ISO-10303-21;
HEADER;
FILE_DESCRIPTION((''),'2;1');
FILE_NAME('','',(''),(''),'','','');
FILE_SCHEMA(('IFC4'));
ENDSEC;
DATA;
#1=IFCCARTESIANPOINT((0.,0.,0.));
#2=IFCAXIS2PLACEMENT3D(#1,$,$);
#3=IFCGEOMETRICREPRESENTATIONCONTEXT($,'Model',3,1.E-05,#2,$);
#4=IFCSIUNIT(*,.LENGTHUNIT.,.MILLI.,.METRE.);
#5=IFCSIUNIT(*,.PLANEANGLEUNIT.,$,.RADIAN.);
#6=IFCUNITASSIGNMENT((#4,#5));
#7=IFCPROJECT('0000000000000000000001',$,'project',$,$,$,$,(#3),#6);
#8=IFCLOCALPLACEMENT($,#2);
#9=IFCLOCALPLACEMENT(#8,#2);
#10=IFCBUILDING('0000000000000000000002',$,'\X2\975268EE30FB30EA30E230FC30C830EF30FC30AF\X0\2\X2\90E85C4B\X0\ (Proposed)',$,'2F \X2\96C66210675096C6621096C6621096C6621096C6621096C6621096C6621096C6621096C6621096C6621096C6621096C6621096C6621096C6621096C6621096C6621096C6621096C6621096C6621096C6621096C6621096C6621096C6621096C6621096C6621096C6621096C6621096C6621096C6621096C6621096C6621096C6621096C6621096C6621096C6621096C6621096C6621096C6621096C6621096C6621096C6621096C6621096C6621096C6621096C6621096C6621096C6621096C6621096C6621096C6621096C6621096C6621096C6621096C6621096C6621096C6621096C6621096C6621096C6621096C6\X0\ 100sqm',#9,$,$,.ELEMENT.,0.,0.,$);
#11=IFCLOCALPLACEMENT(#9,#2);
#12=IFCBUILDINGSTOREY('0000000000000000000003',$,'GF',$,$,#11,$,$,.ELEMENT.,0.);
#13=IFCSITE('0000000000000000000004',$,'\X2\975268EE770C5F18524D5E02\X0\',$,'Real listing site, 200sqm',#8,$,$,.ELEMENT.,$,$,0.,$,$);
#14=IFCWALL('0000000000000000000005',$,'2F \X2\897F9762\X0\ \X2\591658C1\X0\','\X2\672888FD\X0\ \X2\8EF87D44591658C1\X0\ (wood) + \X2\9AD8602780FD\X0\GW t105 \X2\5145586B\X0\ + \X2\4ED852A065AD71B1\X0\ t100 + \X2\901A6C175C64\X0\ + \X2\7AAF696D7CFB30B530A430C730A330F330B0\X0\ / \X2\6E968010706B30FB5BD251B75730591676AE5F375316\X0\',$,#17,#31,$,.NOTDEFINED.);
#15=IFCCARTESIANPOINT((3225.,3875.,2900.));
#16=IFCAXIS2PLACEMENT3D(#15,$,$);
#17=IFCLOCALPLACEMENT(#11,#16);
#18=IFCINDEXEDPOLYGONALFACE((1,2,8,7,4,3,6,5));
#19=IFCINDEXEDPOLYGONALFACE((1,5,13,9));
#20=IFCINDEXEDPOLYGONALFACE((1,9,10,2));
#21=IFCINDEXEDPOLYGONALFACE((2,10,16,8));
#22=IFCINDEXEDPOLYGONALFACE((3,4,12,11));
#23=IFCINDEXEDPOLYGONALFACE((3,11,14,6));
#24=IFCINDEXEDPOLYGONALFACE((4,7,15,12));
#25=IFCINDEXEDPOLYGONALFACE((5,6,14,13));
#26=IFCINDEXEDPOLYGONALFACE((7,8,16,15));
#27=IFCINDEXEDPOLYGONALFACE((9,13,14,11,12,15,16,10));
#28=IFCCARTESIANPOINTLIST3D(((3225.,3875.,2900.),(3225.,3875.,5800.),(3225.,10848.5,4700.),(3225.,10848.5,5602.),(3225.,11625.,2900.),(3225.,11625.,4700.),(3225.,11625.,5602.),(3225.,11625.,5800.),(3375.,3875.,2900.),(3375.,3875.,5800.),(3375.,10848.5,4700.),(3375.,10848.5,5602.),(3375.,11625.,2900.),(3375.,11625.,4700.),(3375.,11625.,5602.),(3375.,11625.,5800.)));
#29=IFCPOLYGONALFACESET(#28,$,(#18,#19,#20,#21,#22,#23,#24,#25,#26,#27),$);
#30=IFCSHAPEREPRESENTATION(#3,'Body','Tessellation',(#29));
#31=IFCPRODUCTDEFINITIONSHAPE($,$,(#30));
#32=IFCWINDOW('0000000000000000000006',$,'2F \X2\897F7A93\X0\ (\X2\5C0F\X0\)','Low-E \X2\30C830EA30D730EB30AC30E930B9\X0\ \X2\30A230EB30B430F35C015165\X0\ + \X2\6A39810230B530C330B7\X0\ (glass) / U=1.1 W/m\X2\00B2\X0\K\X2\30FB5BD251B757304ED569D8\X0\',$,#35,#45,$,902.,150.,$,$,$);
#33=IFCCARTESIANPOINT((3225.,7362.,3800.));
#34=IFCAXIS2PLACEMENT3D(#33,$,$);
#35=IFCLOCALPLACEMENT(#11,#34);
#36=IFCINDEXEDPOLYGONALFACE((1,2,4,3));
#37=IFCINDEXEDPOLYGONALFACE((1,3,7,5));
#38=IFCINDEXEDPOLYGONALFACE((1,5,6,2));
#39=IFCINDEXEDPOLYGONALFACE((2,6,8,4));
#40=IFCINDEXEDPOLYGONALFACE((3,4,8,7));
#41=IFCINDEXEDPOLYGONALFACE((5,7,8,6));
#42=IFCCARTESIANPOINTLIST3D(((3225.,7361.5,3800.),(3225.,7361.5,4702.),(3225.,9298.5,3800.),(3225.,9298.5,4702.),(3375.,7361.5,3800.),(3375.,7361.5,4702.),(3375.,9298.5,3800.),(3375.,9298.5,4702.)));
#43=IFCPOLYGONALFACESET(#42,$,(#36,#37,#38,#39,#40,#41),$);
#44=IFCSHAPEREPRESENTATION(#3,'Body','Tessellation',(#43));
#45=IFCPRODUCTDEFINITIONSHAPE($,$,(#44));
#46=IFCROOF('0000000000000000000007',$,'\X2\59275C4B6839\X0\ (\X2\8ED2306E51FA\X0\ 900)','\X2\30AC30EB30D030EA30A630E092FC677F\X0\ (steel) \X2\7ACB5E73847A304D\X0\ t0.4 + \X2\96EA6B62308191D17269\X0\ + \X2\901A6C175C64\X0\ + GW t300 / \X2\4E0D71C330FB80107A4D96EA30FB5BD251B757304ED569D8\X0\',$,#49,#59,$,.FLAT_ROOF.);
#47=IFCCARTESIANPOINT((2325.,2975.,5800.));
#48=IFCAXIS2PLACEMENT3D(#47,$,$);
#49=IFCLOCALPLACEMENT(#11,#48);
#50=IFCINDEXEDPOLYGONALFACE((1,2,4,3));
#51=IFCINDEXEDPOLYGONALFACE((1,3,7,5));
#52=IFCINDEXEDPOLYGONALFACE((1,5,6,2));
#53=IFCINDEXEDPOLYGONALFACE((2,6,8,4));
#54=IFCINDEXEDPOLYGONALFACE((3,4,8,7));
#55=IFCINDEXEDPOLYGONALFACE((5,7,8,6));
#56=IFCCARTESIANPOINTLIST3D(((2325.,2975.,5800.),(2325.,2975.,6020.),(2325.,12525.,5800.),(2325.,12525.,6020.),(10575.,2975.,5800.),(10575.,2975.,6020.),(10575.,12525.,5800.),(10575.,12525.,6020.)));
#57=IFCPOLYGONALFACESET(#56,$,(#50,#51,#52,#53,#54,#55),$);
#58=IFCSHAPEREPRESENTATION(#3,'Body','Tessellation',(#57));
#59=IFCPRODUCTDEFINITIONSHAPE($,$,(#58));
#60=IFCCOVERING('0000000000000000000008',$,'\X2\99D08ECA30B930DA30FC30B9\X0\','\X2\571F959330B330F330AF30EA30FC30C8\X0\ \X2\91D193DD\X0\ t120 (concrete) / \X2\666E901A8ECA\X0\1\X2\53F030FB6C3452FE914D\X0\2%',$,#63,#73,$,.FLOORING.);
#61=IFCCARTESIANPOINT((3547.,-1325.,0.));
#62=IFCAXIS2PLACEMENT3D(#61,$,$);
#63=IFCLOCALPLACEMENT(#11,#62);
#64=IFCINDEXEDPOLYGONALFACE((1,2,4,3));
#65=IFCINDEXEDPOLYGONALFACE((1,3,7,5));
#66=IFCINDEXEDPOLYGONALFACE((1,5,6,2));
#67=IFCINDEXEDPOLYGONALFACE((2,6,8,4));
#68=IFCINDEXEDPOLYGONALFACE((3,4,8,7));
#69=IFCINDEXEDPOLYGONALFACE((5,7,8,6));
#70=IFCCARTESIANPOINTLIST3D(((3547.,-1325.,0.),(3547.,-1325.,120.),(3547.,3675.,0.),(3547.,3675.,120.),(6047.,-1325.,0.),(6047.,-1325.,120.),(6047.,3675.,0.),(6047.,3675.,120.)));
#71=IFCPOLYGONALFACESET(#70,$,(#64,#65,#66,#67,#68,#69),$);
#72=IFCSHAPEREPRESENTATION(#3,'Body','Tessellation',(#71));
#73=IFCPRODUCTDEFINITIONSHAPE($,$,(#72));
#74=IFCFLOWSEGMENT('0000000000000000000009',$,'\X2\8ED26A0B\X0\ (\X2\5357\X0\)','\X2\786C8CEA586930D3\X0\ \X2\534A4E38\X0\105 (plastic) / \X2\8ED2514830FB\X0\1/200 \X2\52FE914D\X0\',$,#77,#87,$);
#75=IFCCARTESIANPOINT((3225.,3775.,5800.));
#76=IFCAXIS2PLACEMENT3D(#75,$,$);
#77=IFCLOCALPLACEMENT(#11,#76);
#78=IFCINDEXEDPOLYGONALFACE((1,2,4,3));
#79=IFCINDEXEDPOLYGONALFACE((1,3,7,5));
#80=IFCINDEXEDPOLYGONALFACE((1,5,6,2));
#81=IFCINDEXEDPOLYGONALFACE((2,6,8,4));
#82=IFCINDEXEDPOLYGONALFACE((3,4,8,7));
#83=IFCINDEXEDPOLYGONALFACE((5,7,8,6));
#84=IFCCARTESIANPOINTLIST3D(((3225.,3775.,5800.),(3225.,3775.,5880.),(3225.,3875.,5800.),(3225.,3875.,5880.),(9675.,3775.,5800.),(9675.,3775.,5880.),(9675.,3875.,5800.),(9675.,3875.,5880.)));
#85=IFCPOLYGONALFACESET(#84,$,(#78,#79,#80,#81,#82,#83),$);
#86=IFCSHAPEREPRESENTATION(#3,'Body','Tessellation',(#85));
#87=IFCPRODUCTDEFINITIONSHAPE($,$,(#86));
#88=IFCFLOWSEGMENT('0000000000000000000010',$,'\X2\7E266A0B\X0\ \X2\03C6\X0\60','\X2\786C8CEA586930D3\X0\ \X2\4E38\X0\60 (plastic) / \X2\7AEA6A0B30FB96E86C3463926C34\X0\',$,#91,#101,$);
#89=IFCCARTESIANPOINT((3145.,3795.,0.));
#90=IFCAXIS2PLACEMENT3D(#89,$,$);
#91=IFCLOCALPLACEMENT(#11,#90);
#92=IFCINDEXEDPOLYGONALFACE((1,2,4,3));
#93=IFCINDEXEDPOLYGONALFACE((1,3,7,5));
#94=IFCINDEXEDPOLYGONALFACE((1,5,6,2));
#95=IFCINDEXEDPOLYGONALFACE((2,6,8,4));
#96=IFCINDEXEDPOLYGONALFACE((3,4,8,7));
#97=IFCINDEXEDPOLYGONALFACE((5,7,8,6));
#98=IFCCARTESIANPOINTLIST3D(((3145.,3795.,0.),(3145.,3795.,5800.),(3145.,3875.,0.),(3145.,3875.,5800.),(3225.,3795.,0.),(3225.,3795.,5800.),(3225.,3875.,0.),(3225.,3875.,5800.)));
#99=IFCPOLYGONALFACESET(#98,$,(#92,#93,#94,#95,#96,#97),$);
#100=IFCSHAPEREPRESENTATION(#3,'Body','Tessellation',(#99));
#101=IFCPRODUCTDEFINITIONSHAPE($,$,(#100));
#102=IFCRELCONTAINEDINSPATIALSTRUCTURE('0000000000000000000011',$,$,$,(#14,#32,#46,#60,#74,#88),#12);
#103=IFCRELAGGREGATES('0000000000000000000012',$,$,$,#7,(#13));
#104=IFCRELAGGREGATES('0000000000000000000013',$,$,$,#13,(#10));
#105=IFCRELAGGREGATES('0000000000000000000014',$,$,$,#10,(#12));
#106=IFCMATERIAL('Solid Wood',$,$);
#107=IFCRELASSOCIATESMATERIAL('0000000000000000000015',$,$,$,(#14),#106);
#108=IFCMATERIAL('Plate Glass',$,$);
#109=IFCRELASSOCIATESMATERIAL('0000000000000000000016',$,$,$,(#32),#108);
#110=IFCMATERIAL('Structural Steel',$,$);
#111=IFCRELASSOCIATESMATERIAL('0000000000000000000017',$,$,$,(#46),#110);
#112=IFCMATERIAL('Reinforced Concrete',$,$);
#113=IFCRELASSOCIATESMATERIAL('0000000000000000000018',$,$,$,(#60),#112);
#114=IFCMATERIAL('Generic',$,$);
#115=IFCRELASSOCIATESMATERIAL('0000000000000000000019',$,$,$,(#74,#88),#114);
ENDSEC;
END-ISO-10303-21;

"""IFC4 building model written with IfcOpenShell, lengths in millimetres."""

from ifc_helpers import new_model, si_unit, frame, frame_2d, origin, place, context, project, spatial, rectangle, extrude, material, element, fill, save


model = new_model("IFC4")

# Units and contexts
model_context = context("Model", 3, precision=1e-05, world=origin())
ifc_project = project(units=[si_unit("LENGTHUNIT", "METRE", prefix="MILLI"), si_unit("PLANEANGLEUNIT", "RADIAN")], contexts=[model_context])

# Site, building, storey
site_placement = place(None, origin())
site = spatial("IfcSite", under=ifc_project, at=site_placement, Name="青森県弘前市", ObjectType="Real listing site, 200sqm", CompositionType="ELEMENT", RefElevation=0.0)
building_placement = place(site_placement, origin())
building = spatial("IfcBuilding", under=site, at=building_placement, Name="青森・リモートワーク2部屋 (Proposed)", ObjectType="2F 集成材集成集成集成集成集成集成集成集成集成集成集成集成集成集成集成集成集成集成集成集成集成集成集成集成集成集成集成集成集成集成集成集成集成集成集成集成集成集成集成集成集成集成集成集成集成集成集成集成集成集成集成集成集成集成集成集成集成集成集 100sqm", CompositionType="ELEMENT", ElevationOfRefHeight=0.0, ElevationOfTerrain=0.0)
storey_placement = place(building_placement, origin())
storey = spatial("IfcBuildingStorey", under=building, at=storey_placement, Name="GF", CompositionType="ELEMENT", Elevation=0.0)

# Shared definitions
ifc_material_1 = material(Name="Solid Wood")

# Shared definitions
ifc_material_2 = material(Name="Reinforced Concrete")

# Shared definitions
ifc_material_3 = material(Name="Plate Glass")

# Wall, opening, window
wall_1_placement = place(storey_placement, frame((3225.0, 3875.0, 2900.0)))
wall_1 = element("IfcWall", 1, at=wall_1_placement, inside=storey, material=ifc_material_1, Name="2F 西面 外壁", Description="木製 軸組外壁 (wood) + 高性能GW t105 充填 + 付加断熱 t100 + 通気層 + 窯業系サイディング / 準耐火・寒冷地外皮強化", PredefinedType="NOTDEFINED", context=model_context, shape_type="SweptSolid", body=[
    extrude(rectangle(XDim=150.0, YDim=7750.0, at=frame_2d((75.0, 3875.0))), frame((3225.0, 3875.0, 2900.0)), (0.0, 0.0, 1.0), 2900.0),
])
opening_1_placement = place(storey_placement, frame((3225.0, 7362.0, 3800.0)))
opening_1 = element("IfcOpeningElement", 2, at=opening_1_placement, cuts=wall_1, PredefinedType="NOTDEFINED", context=model_context, shape_type="SweptSolid", body=[
    extrude(rectangle(XDim=150.0, YDim=1937.0, at=frame_2d((75.0, 968.0))), frame((3225.0, 7362.0, 3800.0)), (0.0, 0.0, 1.0), 902.0),
])
window_1_placement = place(storey_placement, frame((3225.0, 7362.0, 3800.0)))
window_1 = element("IfcWindow", 3, at=window_1_placement, inside=storey, material=ifc_material_3, Name="2F 西窓 (小)", Description="Low-E トリプルガラス アルゴン封入 + 樹脂サッシ (glass) / U=1.1 W/m²K・寒冷地仕様", OverallHeight=902.0, OverallWidth=150.0, context=model_context, shape_type="SweptSolid", body=[
    extrude(rectangle(XDim=150.0, YDim=1937.0, at=frame_2d((75.0, 968.0))), frame((3225.0, 7362.0, 3800.0)), (0.0, 0.0, 1.0), 902.0),
])
fill(opening_1, window_1)

# Roof
ifc_material_4 = material(Name="Structural Steel")
roof_placement = place(storey_placement, frame((2325.0, 2975.0, 5800.0)))
element("IfcRoof", 4, at=roof_placement, inside=storey, material=ifc_material_4, Name="大屋根 (軒の出 900)", Description="ガルバリウム鋼板 (steel) 立平葺き t0.4 + 雪止め金物 + 通気層 + GW t300 / 不燃・耐積雪・寒冷地仕様", PredefinedType="FLAT_ROOF", context=model_context, shape_type="SweptSolid", body=[
    extrude(rectangle(XDim=8250.0, YDim=9550.0, at=frame_2d((4125.0, 4775.0))), frame((2325.0, 2975.0, 5800.0)), (0.0, 0.0, 1.0), 220.0),
])

# Covering
covering_placement = place(storey_placement, frame((3547.0, -1325.0, 0.0)))
element("IfcCovering", 5, at=covering_placement, inside=storey, material=ifc_material_2, Name="駐車スペース", Description="土間コンクリート 金鏝 t120 (concrete) / 普通車1台・水勾配2%", PredefinedType="FLOORING", context=model_context, shape_type="SweptSolid", body=[
    extrude(rectangle(XDim=2500.0, YDim=5000.0, at=frame_2d((1250.0, 2500.0))), frame((3547.0, -1325.0, 0.0)), (0.0, 0.0, 1.0), 120.0),
])

# Flow segments
ifc_material_5 = material(Name="Generic")
flow_segment_1_placement = place(storey_placement, frame((3225.0, 3775.0, 5800.0)))
element("IfcFlowSegment", 6, at=flow_segment_1_placement, inside=storey, material=ifc_material_5, Name="軒樋 (南)", Description="硬質塩ビ 半丸105 (plastic) / 軒先・1/200 勾配", context=model_context, shape_type="SweptSolid", body=[
    extrude(rectangle(XDim=6450.0, YDim=100.0, at=frame_2d((3225.0, 50.0))), frame((3225.0, 3775.0, 5800.0)), (0.0, 0.0, 1.0), 80.0),
])
flow_segment_2_placement = place(storey_placement, frame((3145.0, 3795.0, 0.0)))
element("IfcFlowSegment", 7, at=flow_segment_2_placement, inside=storey, material=ifc_material_5, Name="縦樋 φ60", Description="硬質塩ビ 丸60 (plastic) / 竪樋・雨水排水", context=model_context, shape_type="SweptSolid", body=[
    extrude(rectangle(XDim=80.0, YDim=80.0, at=frame_2d((40.0, 40.0))), frame((3145.0, 3795.0, 0.0)), (0.0, 0.0, 1.0), 5800.0),
])

save(model, "model.ifc")
